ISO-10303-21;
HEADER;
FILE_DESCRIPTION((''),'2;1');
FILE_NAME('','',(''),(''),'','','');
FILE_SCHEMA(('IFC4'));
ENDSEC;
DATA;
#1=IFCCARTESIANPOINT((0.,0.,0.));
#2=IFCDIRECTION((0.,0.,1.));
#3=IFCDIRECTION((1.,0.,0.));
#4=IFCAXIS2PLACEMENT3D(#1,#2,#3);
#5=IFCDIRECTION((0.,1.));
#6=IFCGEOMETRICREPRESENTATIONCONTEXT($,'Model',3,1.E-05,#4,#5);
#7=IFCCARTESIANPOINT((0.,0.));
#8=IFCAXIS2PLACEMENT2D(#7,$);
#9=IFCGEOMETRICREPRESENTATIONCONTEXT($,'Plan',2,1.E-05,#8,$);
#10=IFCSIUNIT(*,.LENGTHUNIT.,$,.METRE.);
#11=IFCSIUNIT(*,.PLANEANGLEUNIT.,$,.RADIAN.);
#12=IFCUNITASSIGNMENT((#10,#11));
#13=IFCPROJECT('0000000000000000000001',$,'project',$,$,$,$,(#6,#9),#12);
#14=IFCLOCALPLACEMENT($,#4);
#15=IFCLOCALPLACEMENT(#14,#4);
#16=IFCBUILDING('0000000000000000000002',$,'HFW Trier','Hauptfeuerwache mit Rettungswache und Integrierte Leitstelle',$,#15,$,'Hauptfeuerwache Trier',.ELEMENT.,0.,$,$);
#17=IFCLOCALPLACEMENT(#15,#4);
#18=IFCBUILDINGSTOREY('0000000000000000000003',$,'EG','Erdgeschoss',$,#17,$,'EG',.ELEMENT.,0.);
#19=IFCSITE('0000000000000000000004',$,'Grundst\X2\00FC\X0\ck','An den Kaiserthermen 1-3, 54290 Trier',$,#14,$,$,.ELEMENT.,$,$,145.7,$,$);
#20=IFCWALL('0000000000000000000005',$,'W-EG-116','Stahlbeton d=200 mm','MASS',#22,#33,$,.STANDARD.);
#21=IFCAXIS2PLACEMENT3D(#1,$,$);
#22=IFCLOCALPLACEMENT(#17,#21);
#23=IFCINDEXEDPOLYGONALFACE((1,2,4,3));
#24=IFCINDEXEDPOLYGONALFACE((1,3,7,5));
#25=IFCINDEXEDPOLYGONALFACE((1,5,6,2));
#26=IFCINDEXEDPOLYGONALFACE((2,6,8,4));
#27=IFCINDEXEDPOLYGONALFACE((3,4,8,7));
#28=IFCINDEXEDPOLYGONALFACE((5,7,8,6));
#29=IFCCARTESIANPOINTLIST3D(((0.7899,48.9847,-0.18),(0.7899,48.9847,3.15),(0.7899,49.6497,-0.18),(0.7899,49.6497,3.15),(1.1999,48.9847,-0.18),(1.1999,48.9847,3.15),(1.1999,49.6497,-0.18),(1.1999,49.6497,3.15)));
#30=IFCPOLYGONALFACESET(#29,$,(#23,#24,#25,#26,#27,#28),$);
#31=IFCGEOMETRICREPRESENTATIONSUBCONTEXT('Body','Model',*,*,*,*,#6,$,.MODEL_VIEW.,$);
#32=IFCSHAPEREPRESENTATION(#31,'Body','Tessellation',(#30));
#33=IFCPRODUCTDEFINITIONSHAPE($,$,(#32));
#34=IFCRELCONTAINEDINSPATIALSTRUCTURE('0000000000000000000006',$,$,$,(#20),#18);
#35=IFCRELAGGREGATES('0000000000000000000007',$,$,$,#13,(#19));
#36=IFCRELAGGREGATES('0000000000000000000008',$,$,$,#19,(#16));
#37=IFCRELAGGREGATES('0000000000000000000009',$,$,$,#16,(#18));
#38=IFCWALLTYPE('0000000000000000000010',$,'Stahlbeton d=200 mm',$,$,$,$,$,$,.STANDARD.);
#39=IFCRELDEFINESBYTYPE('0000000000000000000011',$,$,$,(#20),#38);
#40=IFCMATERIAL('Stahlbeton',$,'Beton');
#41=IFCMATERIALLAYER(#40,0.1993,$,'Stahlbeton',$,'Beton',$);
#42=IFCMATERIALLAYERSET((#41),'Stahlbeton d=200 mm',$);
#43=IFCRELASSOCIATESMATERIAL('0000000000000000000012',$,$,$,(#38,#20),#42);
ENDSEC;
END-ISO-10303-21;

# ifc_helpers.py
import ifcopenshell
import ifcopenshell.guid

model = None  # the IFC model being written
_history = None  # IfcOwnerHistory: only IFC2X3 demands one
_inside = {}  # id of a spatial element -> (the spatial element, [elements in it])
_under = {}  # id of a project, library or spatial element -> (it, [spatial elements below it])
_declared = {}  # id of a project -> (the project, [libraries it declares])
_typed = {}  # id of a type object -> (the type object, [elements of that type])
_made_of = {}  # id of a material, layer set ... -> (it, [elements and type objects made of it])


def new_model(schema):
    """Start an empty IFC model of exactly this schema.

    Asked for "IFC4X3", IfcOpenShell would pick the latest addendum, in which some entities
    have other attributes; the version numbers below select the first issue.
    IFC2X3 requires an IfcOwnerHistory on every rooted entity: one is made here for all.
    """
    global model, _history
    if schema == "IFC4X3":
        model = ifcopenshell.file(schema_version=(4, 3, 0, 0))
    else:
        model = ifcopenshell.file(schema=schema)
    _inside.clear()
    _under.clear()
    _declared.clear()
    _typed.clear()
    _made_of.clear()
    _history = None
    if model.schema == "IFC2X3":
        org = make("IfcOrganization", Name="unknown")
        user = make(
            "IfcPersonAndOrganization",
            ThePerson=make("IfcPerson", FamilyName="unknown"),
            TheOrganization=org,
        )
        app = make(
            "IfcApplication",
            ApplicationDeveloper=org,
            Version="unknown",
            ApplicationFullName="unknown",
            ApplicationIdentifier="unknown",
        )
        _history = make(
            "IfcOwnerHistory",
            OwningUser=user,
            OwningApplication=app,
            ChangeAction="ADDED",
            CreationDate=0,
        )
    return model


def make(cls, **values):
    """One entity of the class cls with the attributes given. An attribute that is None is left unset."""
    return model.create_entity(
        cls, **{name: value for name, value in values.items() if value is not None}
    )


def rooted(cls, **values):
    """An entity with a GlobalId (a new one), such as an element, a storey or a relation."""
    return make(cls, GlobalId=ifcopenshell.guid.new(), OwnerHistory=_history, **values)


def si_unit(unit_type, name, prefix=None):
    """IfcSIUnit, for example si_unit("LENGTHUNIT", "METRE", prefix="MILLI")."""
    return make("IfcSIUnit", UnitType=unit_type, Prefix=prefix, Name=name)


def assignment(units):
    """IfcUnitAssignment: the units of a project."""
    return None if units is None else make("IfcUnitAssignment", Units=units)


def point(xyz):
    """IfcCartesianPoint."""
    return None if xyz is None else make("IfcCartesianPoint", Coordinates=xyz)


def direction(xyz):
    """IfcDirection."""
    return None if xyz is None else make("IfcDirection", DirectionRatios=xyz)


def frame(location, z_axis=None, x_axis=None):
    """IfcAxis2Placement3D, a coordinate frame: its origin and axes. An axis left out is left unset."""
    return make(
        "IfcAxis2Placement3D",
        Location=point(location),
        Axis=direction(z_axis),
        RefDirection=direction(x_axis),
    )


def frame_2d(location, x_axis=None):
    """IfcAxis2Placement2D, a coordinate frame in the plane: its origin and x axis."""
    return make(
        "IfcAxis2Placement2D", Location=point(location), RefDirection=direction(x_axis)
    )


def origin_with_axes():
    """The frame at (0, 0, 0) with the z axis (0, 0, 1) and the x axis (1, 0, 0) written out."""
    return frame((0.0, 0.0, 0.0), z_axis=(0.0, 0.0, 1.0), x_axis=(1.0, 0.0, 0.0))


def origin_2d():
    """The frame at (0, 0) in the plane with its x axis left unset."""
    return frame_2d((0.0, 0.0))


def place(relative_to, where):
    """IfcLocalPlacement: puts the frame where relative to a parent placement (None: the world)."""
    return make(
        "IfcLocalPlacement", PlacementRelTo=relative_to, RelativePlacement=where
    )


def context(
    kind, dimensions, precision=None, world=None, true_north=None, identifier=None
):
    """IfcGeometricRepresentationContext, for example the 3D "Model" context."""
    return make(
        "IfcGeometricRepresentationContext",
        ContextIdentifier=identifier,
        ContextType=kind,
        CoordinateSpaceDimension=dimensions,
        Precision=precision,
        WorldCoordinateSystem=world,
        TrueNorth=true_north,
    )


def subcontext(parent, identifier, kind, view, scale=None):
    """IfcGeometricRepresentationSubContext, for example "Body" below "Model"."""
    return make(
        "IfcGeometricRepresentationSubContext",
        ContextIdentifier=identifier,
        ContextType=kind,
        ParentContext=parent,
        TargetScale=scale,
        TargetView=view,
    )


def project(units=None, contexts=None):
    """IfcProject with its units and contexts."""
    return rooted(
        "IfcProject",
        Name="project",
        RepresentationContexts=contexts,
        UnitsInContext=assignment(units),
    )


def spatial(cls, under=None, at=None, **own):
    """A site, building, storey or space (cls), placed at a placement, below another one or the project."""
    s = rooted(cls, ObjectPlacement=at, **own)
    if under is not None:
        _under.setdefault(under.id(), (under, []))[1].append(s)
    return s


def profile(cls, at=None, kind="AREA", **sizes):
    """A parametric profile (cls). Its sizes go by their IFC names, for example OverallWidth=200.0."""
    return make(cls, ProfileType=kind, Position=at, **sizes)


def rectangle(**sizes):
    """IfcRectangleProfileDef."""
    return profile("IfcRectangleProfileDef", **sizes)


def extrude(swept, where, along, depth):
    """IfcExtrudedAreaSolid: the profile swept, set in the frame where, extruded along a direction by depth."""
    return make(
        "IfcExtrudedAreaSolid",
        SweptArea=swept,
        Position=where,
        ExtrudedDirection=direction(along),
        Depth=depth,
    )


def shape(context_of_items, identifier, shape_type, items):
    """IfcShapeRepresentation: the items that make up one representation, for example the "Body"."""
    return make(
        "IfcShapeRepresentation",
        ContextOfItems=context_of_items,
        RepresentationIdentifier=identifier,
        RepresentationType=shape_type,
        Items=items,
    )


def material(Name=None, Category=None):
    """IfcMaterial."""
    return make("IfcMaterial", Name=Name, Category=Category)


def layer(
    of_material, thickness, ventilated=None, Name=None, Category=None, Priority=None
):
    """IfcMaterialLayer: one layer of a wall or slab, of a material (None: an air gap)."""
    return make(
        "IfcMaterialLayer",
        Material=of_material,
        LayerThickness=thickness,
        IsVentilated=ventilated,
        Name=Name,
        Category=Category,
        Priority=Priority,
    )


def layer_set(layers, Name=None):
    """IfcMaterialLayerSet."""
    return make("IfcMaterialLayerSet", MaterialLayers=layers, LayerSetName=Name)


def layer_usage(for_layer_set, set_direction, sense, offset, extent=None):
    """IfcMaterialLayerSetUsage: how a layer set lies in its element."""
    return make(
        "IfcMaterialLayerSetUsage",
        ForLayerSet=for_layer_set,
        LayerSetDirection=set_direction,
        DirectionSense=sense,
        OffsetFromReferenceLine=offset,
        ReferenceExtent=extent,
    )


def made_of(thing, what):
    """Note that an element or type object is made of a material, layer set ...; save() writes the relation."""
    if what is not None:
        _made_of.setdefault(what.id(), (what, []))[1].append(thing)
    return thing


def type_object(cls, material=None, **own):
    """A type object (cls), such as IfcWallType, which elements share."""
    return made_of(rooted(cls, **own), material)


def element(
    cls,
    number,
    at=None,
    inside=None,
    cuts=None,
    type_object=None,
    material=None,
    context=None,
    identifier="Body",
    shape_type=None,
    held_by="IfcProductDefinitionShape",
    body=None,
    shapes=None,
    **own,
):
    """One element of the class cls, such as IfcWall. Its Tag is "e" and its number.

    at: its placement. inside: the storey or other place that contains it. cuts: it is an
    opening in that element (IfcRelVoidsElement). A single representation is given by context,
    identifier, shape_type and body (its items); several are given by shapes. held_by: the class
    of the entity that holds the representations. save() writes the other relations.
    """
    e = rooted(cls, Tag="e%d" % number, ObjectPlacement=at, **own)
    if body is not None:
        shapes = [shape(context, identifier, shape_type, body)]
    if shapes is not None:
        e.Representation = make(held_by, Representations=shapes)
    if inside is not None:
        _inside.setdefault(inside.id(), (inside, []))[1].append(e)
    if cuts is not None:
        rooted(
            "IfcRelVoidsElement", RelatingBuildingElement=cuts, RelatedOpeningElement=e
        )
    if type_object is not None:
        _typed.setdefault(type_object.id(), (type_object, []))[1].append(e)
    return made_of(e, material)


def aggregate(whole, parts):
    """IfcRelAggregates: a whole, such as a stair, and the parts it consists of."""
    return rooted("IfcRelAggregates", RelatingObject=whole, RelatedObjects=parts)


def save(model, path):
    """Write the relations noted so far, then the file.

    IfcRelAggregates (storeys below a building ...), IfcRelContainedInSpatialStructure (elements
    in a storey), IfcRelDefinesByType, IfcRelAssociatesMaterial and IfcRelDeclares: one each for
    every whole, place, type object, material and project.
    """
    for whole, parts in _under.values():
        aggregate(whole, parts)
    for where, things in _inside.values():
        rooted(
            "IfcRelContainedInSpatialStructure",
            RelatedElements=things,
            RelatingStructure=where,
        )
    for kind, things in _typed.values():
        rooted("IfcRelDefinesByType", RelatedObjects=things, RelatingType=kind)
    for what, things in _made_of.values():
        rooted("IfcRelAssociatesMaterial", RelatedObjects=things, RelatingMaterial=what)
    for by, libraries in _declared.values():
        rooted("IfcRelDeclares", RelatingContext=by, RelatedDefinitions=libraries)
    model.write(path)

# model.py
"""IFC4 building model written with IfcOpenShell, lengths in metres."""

from ifc_helpers import new_model, si_unit, direction, frame, frame_2d, origin_with_axes, origin_2d, place, context, subcontext, project, spatial, rectangle, extrude, material, layer, layer_set, layer_usage, type_object, element, save


model = new_model("IFC4")

# Units and contexts
model_context = context("Model", 3, precision=1e-05, world=origin_with_axes(), true_north=direction((0.0, 1.0)))
plan_context = context("Plan", 2, precision=1e-05, world=origin_2d())
body_context = subcontext(model_context, "Body", "Model", "MODEL_VIEW")
ifc_project = project(units=[si_unit("LENGTHUNIT", "METRE"), si_unit("PLANEANGLEUNIT", "RADIAN")], contexts=[model_context, plan_context])

# Site, building, storey
site_placement = place(None, origin_with_axes())
site = spatial("IfcSite", under=ifc_project, at=site_placement, Name="Grundstück", Description="An den Kaiserthermen 1-3, 54290 Trier", CompositionType="ELEMENT", RefElevation=145.7)
building_placement = place(site_placement, origin_with_axes())
building = spatial("IfcBuilding", under=site, at=building_placement, Name="HFW Trier", Description="Hauptfeuerwache mit Rettungswache und Integrierte Leitstelle", LongName="Hauptfeuerwache Trier", CompositionType="ELEMENT", ElevationOfRefHeight=0.0)
storey_placement = place(building_placement, origin_with_axes())
storey = spatial("IfcBuildingStorey", under=building, at=storey_placement, Name="EG", Description="Erdgeschoss", LongName="EG", CompositionType="ELEMENT", Elevation=0.0)

# Wall
ifc_material_1 = material(Name="Stahlbeton", Category="Beton")
ifc_layer_1 = layer(ifc_material_1, 0.1993, Name="Stahlbeton", Category="Beton")
ifc_layer_set_1 = layer_set([ifc_layer_1], Name="Stahlbeton d=200 mm")
ifc_layer_usage_1 = layer_usage(ifc_layer_set_1, "AXIS2", "POSITIVE", -0.205)
wall_type_1 = type_object("IfcWallType", Name="Stahlbeton d=200 mm", PredefinedType="STANDARD", material=ifc_layer_set_1)
wall_1_placement = place(storey_placement, frame((0.9949, 49.6497, -0.18), z_axis=(0.0, 0.0, 1.0), x_axis=(0.0, -1.0, 0.0)))
element("IfcWall", 1, at=wall_1_placement, inside=storey, type_object=wall_type_1, material=ifc_layer_usage_1, Name="W-EG-116", Description="Stahlbeton d=200 mm", ObjectType="MASS", PredefinedType="STANDARD", context=body_context, shape_type="SweptSolid", body=[
    extrude(rectangle(XDim=0.665, YDim=0.41, at=frame_2d((0.3325, 0.0))), origin_with_axes(), (0.0, 0.0, 1.0), 3.33),
])

save(model, "model.ifc")
